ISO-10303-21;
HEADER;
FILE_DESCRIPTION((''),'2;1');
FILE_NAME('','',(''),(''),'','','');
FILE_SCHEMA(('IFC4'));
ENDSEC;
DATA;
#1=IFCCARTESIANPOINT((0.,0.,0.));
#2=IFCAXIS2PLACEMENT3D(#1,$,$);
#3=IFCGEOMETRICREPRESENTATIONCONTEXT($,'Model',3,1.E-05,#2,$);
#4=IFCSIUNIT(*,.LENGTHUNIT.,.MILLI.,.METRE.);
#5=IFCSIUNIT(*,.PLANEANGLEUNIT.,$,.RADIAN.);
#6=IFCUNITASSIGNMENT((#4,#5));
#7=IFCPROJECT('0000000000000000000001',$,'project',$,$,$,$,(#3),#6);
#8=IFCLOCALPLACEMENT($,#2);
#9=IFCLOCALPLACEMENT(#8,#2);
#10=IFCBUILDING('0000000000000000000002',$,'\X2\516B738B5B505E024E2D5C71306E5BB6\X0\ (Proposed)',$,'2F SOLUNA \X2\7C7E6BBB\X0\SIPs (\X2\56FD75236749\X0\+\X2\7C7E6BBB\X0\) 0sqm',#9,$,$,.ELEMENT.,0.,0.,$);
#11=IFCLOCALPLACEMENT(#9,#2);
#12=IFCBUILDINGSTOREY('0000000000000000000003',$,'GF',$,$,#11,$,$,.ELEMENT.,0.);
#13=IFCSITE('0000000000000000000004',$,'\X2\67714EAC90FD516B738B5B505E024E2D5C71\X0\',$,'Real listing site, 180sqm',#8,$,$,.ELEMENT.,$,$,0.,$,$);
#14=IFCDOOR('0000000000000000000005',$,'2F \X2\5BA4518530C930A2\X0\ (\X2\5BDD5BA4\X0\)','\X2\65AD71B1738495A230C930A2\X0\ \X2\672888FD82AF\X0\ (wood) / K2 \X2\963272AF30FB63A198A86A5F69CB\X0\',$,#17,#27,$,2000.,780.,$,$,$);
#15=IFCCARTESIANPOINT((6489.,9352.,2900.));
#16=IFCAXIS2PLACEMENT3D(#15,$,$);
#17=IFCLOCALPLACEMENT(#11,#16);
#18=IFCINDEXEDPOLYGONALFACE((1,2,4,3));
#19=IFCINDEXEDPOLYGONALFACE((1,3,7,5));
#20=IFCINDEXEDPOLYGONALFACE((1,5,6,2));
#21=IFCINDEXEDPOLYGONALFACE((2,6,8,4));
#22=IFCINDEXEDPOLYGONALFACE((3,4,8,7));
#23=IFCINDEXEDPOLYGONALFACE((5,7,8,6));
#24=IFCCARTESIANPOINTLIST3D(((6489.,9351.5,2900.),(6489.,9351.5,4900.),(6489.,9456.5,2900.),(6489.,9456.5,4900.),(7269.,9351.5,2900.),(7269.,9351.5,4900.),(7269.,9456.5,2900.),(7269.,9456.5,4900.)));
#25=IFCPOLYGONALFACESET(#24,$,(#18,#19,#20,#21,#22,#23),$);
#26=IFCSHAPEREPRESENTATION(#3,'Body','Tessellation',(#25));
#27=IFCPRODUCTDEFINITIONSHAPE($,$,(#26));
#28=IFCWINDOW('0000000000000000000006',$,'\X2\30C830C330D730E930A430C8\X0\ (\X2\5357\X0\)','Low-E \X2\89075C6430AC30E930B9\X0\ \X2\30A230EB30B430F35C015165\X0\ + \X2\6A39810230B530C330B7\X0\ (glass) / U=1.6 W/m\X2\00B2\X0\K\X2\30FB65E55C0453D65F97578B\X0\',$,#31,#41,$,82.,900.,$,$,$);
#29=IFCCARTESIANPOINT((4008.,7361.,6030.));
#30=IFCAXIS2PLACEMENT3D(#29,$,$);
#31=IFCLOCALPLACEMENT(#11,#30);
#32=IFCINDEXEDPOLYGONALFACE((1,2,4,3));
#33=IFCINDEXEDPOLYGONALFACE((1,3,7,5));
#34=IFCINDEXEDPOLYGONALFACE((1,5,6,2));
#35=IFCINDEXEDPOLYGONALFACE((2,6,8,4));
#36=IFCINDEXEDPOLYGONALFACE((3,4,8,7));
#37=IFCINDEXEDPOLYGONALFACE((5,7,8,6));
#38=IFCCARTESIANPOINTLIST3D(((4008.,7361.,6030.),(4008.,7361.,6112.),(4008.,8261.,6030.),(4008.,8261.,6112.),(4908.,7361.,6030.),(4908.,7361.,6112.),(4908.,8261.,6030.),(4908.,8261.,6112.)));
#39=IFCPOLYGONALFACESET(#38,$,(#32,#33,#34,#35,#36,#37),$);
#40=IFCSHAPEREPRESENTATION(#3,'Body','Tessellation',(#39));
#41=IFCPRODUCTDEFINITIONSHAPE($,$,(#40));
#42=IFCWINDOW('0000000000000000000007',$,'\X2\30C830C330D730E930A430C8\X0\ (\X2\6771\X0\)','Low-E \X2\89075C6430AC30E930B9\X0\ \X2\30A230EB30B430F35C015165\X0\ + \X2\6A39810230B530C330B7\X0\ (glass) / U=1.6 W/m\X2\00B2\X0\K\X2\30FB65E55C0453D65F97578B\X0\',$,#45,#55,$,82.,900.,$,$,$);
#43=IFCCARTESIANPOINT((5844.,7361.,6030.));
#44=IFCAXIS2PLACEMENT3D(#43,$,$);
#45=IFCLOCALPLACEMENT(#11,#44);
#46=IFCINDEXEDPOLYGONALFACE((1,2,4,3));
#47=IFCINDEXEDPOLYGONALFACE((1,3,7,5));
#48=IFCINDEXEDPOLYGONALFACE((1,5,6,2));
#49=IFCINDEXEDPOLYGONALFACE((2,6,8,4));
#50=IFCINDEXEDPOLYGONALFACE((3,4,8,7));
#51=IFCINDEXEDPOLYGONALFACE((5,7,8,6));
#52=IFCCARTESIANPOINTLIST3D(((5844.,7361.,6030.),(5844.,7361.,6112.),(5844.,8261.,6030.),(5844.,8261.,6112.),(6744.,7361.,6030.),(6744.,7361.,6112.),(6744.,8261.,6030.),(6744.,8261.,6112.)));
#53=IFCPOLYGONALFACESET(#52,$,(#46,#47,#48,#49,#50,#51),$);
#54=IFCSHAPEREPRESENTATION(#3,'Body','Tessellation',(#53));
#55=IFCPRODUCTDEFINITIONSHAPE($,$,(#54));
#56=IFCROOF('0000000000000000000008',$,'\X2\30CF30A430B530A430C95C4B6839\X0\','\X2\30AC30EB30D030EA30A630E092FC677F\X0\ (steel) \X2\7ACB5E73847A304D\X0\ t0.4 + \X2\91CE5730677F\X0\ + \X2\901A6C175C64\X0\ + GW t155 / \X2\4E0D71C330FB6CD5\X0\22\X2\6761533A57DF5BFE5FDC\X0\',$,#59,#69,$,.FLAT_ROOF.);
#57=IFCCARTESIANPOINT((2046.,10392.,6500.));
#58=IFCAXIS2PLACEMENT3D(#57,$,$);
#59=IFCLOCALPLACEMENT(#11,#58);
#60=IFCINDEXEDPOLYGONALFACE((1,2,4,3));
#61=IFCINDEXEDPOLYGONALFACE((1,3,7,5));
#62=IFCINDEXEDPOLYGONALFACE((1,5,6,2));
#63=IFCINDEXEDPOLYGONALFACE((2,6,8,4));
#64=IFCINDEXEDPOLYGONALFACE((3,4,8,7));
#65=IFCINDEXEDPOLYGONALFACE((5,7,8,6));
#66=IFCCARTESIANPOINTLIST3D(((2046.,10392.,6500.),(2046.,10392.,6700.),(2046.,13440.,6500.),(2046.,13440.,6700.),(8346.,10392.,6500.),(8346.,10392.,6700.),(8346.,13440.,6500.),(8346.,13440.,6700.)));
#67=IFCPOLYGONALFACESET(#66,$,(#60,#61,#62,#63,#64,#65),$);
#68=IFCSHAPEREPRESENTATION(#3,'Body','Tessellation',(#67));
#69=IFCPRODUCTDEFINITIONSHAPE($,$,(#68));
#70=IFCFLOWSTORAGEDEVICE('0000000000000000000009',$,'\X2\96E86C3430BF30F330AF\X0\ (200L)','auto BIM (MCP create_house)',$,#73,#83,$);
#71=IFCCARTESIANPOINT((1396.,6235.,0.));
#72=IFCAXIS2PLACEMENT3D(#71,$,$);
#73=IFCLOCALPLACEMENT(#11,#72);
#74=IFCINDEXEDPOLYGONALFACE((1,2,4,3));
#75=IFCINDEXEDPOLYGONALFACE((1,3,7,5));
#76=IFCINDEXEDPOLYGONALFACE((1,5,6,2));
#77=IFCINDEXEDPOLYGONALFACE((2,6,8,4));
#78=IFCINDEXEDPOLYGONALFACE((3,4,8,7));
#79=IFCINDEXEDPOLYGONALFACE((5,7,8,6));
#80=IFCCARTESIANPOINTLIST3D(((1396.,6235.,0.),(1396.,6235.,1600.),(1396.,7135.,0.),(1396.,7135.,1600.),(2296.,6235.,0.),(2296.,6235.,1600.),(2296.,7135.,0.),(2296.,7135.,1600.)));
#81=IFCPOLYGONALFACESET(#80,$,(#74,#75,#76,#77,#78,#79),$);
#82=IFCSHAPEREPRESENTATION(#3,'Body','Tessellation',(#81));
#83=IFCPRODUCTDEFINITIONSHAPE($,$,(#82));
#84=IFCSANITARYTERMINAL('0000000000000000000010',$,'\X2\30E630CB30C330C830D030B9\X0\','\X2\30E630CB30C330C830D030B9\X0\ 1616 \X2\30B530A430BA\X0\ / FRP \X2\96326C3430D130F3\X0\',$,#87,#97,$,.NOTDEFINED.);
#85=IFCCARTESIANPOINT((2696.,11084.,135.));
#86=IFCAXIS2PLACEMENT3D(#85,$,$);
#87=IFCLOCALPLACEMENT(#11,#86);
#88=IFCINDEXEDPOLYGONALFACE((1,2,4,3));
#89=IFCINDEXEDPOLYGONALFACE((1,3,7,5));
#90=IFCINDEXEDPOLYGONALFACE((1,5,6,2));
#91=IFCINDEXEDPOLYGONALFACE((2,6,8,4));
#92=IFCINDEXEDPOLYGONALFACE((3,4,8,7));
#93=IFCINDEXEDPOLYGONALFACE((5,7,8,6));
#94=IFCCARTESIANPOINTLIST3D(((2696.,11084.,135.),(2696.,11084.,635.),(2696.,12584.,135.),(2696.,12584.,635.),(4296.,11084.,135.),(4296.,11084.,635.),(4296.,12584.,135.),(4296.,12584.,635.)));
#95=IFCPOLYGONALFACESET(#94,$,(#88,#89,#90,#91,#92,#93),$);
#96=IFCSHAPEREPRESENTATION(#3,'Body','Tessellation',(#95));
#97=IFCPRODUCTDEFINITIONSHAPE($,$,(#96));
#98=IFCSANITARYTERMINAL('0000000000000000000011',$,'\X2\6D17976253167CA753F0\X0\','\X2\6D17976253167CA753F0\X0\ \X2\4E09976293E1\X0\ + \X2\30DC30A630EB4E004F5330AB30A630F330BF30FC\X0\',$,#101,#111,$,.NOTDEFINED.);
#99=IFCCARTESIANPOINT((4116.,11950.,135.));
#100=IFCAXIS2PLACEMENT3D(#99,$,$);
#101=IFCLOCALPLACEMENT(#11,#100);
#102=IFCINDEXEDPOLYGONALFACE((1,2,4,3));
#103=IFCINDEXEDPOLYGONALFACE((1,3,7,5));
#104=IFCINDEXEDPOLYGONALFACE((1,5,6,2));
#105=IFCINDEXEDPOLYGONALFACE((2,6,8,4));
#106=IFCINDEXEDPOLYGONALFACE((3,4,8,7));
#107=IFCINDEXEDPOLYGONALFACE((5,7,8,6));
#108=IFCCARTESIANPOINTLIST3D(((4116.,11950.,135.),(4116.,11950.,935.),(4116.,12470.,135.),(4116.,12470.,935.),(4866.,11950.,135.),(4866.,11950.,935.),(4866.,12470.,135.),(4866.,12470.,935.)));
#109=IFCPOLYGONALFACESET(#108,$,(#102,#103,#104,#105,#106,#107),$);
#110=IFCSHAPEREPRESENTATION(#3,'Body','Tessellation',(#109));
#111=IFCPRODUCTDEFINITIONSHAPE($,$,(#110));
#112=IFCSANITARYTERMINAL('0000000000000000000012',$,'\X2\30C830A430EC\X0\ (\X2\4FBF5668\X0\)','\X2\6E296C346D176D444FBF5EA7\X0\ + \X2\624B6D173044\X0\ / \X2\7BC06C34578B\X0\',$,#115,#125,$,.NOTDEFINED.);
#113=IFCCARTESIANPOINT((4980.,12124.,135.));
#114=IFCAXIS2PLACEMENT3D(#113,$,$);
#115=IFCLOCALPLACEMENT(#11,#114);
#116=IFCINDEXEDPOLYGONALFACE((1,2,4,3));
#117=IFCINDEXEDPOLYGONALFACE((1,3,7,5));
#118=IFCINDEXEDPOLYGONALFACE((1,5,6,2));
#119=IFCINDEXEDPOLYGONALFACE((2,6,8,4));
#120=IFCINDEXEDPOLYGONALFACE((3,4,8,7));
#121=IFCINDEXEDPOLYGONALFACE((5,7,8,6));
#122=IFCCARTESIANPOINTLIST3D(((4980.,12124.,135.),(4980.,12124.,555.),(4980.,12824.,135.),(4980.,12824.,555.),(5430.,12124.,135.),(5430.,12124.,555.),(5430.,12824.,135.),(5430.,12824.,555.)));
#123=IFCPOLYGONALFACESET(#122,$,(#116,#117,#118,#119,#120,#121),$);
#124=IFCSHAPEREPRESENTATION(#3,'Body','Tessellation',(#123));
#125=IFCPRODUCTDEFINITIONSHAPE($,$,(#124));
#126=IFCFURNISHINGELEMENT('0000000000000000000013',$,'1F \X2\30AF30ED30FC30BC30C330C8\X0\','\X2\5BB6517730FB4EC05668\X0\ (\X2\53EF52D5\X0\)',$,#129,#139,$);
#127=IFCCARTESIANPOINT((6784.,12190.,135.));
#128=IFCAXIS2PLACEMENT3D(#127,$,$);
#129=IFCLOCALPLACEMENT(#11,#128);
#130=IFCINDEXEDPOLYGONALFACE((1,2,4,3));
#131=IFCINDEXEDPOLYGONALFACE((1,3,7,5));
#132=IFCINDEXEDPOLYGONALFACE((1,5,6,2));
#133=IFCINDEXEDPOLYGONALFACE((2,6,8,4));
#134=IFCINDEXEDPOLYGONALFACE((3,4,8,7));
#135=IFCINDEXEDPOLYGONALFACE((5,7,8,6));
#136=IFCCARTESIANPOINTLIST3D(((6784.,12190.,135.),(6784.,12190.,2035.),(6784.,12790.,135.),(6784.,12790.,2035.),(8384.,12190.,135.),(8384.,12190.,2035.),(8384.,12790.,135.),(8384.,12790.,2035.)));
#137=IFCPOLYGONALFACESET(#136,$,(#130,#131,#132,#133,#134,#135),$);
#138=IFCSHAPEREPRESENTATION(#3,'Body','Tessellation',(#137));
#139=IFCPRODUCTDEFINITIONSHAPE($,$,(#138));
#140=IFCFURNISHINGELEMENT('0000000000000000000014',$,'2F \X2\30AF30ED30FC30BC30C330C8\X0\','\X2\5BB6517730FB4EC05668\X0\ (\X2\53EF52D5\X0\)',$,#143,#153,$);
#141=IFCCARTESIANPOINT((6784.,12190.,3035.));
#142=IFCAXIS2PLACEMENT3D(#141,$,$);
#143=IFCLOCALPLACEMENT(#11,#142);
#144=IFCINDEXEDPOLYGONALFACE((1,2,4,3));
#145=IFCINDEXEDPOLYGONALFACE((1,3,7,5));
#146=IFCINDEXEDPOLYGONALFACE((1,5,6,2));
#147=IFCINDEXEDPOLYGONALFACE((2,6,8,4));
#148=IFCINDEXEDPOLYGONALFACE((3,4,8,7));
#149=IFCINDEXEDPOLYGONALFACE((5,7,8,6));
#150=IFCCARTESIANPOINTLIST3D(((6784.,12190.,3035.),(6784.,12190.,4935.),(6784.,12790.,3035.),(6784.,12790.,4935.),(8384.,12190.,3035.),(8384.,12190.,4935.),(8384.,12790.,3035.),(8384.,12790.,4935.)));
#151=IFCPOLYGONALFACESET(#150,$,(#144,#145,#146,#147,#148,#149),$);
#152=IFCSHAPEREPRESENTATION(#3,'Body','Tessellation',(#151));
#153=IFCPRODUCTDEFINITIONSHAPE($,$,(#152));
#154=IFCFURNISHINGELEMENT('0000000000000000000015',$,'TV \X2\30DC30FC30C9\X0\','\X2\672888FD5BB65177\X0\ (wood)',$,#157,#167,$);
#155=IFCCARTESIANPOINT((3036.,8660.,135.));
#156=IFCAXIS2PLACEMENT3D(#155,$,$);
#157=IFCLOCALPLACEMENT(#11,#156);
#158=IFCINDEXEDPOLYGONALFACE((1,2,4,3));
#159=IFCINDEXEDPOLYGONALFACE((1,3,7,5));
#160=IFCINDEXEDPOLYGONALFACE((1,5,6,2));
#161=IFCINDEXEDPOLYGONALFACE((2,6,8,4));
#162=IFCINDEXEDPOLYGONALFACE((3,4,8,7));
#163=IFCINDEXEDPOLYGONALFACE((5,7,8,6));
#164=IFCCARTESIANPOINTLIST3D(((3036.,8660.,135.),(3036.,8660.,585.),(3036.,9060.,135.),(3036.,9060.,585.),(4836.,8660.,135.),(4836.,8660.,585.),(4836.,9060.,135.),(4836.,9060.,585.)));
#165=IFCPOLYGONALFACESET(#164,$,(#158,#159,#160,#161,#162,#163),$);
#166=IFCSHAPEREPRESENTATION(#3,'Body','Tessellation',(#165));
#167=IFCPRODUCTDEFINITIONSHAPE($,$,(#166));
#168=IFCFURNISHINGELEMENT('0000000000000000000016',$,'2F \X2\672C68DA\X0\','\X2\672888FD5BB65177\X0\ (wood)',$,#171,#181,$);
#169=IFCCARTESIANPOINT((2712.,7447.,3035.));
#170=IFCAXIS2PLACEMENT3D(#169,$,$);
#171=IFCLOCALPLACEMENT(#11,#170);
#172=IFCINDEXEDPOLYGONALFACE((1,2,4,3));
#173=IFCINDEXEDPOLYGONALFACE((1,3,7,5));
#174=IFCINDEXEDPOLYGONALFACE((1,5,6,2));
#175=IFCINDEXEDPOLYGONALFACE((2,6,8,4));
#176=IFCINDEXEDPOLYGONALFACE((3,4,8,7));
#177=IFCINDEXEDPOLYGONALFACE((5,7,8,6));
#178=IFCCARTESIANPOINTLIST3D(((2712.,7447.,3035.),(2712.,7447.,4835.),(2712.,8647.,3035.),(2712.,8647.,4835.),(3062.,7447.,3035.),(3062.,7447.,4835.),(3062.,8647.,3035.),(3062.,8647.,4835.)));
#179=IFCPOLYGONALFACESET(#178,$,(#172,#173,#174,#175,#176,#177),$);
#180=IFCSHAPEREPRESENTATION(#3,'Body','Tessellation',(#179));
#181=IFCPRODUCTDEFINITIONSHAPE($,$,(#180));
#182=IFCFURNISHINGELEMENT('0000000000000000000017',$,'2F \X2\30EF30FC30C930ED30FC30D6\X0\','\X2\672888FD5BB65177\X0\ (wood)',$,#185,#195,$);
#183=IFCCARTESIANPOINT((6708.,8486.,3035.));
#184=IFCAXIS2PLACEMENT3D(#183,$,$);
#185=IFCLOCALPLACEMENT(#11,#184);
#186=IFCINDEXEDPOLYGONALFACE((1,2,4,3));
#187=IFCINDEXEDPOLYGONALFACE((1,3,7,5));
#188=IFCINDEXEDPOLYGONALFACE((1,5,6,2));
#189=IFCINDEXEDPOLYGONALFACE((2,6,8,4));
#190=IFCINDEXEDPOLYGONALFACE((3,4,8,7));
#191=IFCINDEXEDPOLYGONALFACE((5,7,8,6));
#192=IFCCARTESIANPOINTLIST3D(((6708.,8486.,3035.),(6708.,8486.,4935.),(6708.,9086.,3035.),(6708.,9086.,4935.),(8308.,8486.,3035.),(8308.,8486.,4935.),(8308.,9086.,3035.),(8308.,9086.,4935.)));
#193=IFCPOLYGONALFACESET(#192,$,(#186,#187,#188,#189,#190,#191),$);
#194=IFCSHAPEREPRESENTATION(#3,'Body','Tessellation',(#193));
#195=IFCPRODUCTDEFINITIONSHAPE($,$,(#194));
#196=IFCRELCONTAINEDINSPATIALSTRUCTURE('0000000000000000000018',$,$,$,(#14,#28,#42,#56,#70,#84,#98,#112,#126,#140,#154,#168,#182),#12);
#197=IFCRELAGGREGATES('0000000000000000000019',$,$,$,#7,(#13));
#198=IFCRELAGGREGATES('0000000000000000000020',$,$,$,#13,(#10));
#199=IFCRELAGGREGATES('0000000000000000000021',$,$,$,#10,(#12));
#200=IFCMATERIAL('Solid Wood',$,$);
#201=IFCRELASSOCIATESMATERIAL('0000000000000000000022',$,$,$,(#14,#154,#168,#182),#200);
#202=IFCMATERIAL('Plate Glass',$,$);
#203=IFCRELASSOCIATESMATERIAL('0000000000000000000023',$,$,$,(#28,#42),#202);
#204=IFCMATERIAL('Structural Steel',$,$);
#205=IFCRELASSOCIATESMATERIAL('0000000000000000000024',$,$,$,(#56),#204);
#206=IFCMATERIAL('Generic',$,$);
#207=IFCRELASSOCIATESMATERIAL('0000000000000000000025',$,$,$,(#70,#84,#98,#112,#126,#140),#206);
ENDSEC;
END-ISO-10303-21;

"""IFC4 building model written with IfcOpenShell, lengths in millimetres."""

from ifc_helpers import new_model, si_unit, frame, frame_2d, origin, place, context, project, spatial, rectangle, extrude, material, element, save


model = new_model("IFC4")

# Units and contexts
model_context = context("Model", 3, precision=1e-05, world=origin())
ifc_project = project(units=[si_unit("LENGTHUNIT", "METRE", prefix="MILLI"), si_unit("PLANEANGLEUNIT", "RADIAN")], contexts=[model_context])

# Site, building, storey
site_placement = place(None, origin())
site = spatial("IfcSite", under=ifc_project, at=site_placement, Name="東京都八王子市中山", ObjectType="Real listing site, 180sqm", CompositionType="ELEMENT", RefElevation=0.0)
building_placement = place(site_placement, origin())
building = spatial("IfcBuilding", under=site, at=building_placement, Name="八王子市中山の家 (Proposed)", ObjectType="2F SOLUNA 籾殻SIPs (国産杉+籾殻) 0sqm", CompositionType="ELEMENT", ElevationOfRefHeight=0.0, ElevationOfTerrain=0.0)
storey_placement = place(building_placement, origin())
storey = spatial("IfcBuildingStorey", under=building, at=storey_placement, Name="GF", CompositionType="ELEMENT", Elevation=0.0)

# Shared definitions
ifc_material_1 = material(Name="Solid Wood")
ifc_material_2 = material(Name="Plate Glass")

# Door
door_1_placement = place(storey_placement, frame((6489.0, 9352.0, 2900.0)))
element("IfcDoor", 1, at=door_1_placement, inside=storey, material=ifc_material_1, Name="2F 室内ドア (寝室)", Description="断熱玄関ドア 木製芯 (wood) / K2 防犯・採風機構", OverallHeight=2000.0, OverallWidth=780.0, context=model_context, shape_type="SweptSolid", body=[
    extrude(rectangle(XDim=780.0, YDim=105.0, at=frame_2d((390.0, 52.0))), frame((6489.0, 9352.0, 2900.0)), (0.0, 0.0, 1.0), 2000.0),
])

# Windows
window_1_placement = place(storey_placement, frame((4008.0, 7361.0, 6030.0)))
element("IfcWindow", 2, at=window_1_placement, inside=storey, material=ifc_material_2, Name="トップライト (南)", Description="Low-E 複層ガラス アルゴン封入 + 樹脂サッシ (glass) / U=1.6 W/m²K・日射取得型", OverallHeight=82.0, OverallWidth=900.0, context=model_context, shape_type="SweptSolid", body=[
    extrude(rectangle(XDim=900.0, YDim=900.0, at=frame_2d((450.0, 450.0))), frame((4008.0, 7361.0, 6030.0)), (0.0, 0.0, 1.0), 82.0),
])
window_2_placement = place(storey_placement, frame((5844.0, 7361.0, 6030.0)))
element("IfcWindow", 3, at=window_2_placement, inside=storey, material=ifc_material_2, Name="トップライト (東)", Description="Low-E 複層ガラス アルゴン封入 + 樹脂サッシ (glass) / U=1.6 W/m²K・日射取得型", OverallHeight=82.0, OverallWidth=900.0, context=model_context, shape_type="SweptSolid", body=[
    extrude(rectangle(XDim=900.0, YDim=900.0, at=frame_2d((450.0, 450.0))), frame((5844.0, 7361.0, 6030.0)), (0.0, 0.0, 1.0), 82.0),
])

# Roof
ifc_material_3 = material(Name="Structural Steel")
roof_placement = place(storey_placement, frame((2046.0, 10392.0, 6500.0)))
element("IfcRoof", 4, at=roof_placement, inside=storey, material=ifc_material_3, Name="ハイサイド屋根", Description="ガルバリウム鋼板 (steel) 立平葺き t0.4 + 野地板 + 通気層 + GW t155 / 不燃・法22条区域対応", PredefinedType="FLAT_ROOF", context=model_context, shape_type="SweptSolid", body=[
    extrude(rectangle(XDim=6300.0, YDim=3048.0, at=frame_2d((3150.0, 1524.0))), frame((2046.0, 10392.0, 6500.0)), (0.0, 0.0, 1.0), 200.0),
])

# Flow storage device
ifc_material_4 = material(Name="Generic")
flow_storage_device_placement = place(storey_placement, frame((1396.0, 6235.0, 0.0)))
element("IfcFlowStorageDevice", 5, at=flow_storage_device_placement, inside=storey, material=ifc_material_4, Name="雨水タンク (200L)", Description="auto BIM (MCP create_house)", context=model_context, shape_type="SweptSolid", body=[
    extrude(rectangle(XDim=900.0, YDim=900.0, at=frame_2d((450.0, 450.0))), frame((1396.0, 6235.0, 0.0)), (0.0, 0.0, 1.0), 1600.0),
])

# Sanitary terminals
sanitary_terminal_1_placement = place(storey_placement, frame((2696.0, 11084.0, 135.0)))
element("IfcSanitaryTerminal", 6, at=sanitary_terminal_1_placement, inside=storey, material=ifc_material_4, Name="ユニットバス", Description="ユニットバス 1616 サイズ / FRP 防水パン", PredefinedType="NOTDEFINED", context=model_context, shape_type="SweptSolid", body=[
    extrude(rectangle(XDim=1600.0, YDim=1500.0, at=frame_2d((800.0, 750.0))), frame((2696.0, 11084.0, 135.0)), (0.0, 0.0, 1.0), 500.0),
])
sanitary_terminal_2_placement = place(storey_placement, frame((4116.0, 11950.0, 135.0)))
element("IfcSanitaryTerminal", 7, at=sanitary_terminal_2_placement, inside=storey, material=ifc_material_4, Name="洗面化粧台", Description="洗面化粧台 三面鏡 + ボウル一体カウンター", PredefinedType="NOTDEFINED", context=model_context, shape_type="SweptSolid", body=[
    extrude(rectangle(XDim=750.0, YDim=520.0, at=frame_2d((375.0, 260.0))), frame((4116.0, 11950.0, 135.0)), (0.0, 0.0, 1.0), 800.0),
])
sanitary_terminal_3_placement = place(storey_placement, frame((4980.0, 12124.0, 135.0)))
element("IfcSanitaryTerminal", 8, at=sanitary_terminal_3_placement, inside=storey, material=ifc_material_4, Name="トイレ (便器)", Description="温水洗浄便座 + 手洗い / 節水型", PredefinedType="NOTDEFINED", context=model_context, shape_type="SweptSolid", body=[
    extrude(rectangle(XDim=450.0, YDim=700.0, at=frame_2d((225.0, 350.0))), frame((4980.0, 12124.0, 135.0)), (0.0, 0.0, 1.0), 420.0),
])

# Furnishing elements
furnishing_1_placement = place(storey_placement, frame((6784.0, 12190.0, 135.0)))
element("IfcFurnishingElement", 9, at=furnishing_1_placement, inside=storey, material=ifc_material_4, Name="1F クローゼット", Description="家具・什器 (可動)", context=model_context, shape_type="SweptSolid", body=[
    extrude(rectangle(XDim=1600.0, YDim=600.0, at=frame_2d((800.0, 300.0))), frame((6784.0, 12190.0, 135.0)), (0.0, 0.0, 1.0), 1900.0),
])
furnishing_2_placement = place(storey_placement, frame((6784.0, 12190.0, 3035.0)))
element("IfcFurnishingElement", 10, at=furnishing_2_placement, inside=storey, material=ifc_material_4, Name="2F クローゼット", Description="家具・什器 (可動)", context=model_context, shape_type="SweptSolid", body=[
    extrude(rectangle(XDim=1600.0, YDim=600.0, at=frame_2d((800.0, 300.0))), frame((6784.0, 12190.0, 3035.0)), (0.0, 0.0, 1.0), 1900.0),
])
furnishing_3_placement = place(storey_placement, frame((3036.0, 8660.0, 135.0)))
element("IfcFurnishingElement", 11, at=furnishing_3_placement, inside=storey, material=ifc_material_1, Name="TV ボード", Description="木製家具 (wood)", context=model_context, shape_type="SweptSolid", body=[
    extrude(rectangle(XDim=1800.0, YDim=400.0, at=frame_2d((900.0, 200.0))), frame((3036.0, 8660.0, 135.0)), (0.0, 0.0, 1.0), 450.0),
])
furnishing_4_placement = place(storey_placement, frame((2712.0, 7447.0, 3035.0)))
element("IfcFurnishingElement", 12, at=furnishing_4_placement, inside=storey, material=ifc_material_1, Name="2F 本棚", Description="木製家具 (wood)", context=model_context, shape_type="SweptSolid", body=[
    extrude(rectangle(XDim=350.0, YDim=1200.0, at=frame_2d((175.0, 600.0))), frame((2712.0, 7447.0, 3035.0)), (0.0, 0.0, 1.0), 1800.0),
])
furnishing_5_placement = place(storey_placement, frame((6708.0, 8486.0, 3035.0)))
element("IfcFurnishingElement", 13, at=furnishing_5_placement, inside=storey, material=ifc_material_1, Name="2F ワードローブ", Description="木製家具 (wood)", context=model_context, shape_type="SweptSolid", body=[
    extrude(rectangle(XDim=1600.0, YDim=600.0, at=frame_2d((800.0, 300.0))), frame((6708.0, 8486.0, 3035.0)), (0.0, 0.0, 1.0), 1900.0),
])

save(model, "model.ifc")
